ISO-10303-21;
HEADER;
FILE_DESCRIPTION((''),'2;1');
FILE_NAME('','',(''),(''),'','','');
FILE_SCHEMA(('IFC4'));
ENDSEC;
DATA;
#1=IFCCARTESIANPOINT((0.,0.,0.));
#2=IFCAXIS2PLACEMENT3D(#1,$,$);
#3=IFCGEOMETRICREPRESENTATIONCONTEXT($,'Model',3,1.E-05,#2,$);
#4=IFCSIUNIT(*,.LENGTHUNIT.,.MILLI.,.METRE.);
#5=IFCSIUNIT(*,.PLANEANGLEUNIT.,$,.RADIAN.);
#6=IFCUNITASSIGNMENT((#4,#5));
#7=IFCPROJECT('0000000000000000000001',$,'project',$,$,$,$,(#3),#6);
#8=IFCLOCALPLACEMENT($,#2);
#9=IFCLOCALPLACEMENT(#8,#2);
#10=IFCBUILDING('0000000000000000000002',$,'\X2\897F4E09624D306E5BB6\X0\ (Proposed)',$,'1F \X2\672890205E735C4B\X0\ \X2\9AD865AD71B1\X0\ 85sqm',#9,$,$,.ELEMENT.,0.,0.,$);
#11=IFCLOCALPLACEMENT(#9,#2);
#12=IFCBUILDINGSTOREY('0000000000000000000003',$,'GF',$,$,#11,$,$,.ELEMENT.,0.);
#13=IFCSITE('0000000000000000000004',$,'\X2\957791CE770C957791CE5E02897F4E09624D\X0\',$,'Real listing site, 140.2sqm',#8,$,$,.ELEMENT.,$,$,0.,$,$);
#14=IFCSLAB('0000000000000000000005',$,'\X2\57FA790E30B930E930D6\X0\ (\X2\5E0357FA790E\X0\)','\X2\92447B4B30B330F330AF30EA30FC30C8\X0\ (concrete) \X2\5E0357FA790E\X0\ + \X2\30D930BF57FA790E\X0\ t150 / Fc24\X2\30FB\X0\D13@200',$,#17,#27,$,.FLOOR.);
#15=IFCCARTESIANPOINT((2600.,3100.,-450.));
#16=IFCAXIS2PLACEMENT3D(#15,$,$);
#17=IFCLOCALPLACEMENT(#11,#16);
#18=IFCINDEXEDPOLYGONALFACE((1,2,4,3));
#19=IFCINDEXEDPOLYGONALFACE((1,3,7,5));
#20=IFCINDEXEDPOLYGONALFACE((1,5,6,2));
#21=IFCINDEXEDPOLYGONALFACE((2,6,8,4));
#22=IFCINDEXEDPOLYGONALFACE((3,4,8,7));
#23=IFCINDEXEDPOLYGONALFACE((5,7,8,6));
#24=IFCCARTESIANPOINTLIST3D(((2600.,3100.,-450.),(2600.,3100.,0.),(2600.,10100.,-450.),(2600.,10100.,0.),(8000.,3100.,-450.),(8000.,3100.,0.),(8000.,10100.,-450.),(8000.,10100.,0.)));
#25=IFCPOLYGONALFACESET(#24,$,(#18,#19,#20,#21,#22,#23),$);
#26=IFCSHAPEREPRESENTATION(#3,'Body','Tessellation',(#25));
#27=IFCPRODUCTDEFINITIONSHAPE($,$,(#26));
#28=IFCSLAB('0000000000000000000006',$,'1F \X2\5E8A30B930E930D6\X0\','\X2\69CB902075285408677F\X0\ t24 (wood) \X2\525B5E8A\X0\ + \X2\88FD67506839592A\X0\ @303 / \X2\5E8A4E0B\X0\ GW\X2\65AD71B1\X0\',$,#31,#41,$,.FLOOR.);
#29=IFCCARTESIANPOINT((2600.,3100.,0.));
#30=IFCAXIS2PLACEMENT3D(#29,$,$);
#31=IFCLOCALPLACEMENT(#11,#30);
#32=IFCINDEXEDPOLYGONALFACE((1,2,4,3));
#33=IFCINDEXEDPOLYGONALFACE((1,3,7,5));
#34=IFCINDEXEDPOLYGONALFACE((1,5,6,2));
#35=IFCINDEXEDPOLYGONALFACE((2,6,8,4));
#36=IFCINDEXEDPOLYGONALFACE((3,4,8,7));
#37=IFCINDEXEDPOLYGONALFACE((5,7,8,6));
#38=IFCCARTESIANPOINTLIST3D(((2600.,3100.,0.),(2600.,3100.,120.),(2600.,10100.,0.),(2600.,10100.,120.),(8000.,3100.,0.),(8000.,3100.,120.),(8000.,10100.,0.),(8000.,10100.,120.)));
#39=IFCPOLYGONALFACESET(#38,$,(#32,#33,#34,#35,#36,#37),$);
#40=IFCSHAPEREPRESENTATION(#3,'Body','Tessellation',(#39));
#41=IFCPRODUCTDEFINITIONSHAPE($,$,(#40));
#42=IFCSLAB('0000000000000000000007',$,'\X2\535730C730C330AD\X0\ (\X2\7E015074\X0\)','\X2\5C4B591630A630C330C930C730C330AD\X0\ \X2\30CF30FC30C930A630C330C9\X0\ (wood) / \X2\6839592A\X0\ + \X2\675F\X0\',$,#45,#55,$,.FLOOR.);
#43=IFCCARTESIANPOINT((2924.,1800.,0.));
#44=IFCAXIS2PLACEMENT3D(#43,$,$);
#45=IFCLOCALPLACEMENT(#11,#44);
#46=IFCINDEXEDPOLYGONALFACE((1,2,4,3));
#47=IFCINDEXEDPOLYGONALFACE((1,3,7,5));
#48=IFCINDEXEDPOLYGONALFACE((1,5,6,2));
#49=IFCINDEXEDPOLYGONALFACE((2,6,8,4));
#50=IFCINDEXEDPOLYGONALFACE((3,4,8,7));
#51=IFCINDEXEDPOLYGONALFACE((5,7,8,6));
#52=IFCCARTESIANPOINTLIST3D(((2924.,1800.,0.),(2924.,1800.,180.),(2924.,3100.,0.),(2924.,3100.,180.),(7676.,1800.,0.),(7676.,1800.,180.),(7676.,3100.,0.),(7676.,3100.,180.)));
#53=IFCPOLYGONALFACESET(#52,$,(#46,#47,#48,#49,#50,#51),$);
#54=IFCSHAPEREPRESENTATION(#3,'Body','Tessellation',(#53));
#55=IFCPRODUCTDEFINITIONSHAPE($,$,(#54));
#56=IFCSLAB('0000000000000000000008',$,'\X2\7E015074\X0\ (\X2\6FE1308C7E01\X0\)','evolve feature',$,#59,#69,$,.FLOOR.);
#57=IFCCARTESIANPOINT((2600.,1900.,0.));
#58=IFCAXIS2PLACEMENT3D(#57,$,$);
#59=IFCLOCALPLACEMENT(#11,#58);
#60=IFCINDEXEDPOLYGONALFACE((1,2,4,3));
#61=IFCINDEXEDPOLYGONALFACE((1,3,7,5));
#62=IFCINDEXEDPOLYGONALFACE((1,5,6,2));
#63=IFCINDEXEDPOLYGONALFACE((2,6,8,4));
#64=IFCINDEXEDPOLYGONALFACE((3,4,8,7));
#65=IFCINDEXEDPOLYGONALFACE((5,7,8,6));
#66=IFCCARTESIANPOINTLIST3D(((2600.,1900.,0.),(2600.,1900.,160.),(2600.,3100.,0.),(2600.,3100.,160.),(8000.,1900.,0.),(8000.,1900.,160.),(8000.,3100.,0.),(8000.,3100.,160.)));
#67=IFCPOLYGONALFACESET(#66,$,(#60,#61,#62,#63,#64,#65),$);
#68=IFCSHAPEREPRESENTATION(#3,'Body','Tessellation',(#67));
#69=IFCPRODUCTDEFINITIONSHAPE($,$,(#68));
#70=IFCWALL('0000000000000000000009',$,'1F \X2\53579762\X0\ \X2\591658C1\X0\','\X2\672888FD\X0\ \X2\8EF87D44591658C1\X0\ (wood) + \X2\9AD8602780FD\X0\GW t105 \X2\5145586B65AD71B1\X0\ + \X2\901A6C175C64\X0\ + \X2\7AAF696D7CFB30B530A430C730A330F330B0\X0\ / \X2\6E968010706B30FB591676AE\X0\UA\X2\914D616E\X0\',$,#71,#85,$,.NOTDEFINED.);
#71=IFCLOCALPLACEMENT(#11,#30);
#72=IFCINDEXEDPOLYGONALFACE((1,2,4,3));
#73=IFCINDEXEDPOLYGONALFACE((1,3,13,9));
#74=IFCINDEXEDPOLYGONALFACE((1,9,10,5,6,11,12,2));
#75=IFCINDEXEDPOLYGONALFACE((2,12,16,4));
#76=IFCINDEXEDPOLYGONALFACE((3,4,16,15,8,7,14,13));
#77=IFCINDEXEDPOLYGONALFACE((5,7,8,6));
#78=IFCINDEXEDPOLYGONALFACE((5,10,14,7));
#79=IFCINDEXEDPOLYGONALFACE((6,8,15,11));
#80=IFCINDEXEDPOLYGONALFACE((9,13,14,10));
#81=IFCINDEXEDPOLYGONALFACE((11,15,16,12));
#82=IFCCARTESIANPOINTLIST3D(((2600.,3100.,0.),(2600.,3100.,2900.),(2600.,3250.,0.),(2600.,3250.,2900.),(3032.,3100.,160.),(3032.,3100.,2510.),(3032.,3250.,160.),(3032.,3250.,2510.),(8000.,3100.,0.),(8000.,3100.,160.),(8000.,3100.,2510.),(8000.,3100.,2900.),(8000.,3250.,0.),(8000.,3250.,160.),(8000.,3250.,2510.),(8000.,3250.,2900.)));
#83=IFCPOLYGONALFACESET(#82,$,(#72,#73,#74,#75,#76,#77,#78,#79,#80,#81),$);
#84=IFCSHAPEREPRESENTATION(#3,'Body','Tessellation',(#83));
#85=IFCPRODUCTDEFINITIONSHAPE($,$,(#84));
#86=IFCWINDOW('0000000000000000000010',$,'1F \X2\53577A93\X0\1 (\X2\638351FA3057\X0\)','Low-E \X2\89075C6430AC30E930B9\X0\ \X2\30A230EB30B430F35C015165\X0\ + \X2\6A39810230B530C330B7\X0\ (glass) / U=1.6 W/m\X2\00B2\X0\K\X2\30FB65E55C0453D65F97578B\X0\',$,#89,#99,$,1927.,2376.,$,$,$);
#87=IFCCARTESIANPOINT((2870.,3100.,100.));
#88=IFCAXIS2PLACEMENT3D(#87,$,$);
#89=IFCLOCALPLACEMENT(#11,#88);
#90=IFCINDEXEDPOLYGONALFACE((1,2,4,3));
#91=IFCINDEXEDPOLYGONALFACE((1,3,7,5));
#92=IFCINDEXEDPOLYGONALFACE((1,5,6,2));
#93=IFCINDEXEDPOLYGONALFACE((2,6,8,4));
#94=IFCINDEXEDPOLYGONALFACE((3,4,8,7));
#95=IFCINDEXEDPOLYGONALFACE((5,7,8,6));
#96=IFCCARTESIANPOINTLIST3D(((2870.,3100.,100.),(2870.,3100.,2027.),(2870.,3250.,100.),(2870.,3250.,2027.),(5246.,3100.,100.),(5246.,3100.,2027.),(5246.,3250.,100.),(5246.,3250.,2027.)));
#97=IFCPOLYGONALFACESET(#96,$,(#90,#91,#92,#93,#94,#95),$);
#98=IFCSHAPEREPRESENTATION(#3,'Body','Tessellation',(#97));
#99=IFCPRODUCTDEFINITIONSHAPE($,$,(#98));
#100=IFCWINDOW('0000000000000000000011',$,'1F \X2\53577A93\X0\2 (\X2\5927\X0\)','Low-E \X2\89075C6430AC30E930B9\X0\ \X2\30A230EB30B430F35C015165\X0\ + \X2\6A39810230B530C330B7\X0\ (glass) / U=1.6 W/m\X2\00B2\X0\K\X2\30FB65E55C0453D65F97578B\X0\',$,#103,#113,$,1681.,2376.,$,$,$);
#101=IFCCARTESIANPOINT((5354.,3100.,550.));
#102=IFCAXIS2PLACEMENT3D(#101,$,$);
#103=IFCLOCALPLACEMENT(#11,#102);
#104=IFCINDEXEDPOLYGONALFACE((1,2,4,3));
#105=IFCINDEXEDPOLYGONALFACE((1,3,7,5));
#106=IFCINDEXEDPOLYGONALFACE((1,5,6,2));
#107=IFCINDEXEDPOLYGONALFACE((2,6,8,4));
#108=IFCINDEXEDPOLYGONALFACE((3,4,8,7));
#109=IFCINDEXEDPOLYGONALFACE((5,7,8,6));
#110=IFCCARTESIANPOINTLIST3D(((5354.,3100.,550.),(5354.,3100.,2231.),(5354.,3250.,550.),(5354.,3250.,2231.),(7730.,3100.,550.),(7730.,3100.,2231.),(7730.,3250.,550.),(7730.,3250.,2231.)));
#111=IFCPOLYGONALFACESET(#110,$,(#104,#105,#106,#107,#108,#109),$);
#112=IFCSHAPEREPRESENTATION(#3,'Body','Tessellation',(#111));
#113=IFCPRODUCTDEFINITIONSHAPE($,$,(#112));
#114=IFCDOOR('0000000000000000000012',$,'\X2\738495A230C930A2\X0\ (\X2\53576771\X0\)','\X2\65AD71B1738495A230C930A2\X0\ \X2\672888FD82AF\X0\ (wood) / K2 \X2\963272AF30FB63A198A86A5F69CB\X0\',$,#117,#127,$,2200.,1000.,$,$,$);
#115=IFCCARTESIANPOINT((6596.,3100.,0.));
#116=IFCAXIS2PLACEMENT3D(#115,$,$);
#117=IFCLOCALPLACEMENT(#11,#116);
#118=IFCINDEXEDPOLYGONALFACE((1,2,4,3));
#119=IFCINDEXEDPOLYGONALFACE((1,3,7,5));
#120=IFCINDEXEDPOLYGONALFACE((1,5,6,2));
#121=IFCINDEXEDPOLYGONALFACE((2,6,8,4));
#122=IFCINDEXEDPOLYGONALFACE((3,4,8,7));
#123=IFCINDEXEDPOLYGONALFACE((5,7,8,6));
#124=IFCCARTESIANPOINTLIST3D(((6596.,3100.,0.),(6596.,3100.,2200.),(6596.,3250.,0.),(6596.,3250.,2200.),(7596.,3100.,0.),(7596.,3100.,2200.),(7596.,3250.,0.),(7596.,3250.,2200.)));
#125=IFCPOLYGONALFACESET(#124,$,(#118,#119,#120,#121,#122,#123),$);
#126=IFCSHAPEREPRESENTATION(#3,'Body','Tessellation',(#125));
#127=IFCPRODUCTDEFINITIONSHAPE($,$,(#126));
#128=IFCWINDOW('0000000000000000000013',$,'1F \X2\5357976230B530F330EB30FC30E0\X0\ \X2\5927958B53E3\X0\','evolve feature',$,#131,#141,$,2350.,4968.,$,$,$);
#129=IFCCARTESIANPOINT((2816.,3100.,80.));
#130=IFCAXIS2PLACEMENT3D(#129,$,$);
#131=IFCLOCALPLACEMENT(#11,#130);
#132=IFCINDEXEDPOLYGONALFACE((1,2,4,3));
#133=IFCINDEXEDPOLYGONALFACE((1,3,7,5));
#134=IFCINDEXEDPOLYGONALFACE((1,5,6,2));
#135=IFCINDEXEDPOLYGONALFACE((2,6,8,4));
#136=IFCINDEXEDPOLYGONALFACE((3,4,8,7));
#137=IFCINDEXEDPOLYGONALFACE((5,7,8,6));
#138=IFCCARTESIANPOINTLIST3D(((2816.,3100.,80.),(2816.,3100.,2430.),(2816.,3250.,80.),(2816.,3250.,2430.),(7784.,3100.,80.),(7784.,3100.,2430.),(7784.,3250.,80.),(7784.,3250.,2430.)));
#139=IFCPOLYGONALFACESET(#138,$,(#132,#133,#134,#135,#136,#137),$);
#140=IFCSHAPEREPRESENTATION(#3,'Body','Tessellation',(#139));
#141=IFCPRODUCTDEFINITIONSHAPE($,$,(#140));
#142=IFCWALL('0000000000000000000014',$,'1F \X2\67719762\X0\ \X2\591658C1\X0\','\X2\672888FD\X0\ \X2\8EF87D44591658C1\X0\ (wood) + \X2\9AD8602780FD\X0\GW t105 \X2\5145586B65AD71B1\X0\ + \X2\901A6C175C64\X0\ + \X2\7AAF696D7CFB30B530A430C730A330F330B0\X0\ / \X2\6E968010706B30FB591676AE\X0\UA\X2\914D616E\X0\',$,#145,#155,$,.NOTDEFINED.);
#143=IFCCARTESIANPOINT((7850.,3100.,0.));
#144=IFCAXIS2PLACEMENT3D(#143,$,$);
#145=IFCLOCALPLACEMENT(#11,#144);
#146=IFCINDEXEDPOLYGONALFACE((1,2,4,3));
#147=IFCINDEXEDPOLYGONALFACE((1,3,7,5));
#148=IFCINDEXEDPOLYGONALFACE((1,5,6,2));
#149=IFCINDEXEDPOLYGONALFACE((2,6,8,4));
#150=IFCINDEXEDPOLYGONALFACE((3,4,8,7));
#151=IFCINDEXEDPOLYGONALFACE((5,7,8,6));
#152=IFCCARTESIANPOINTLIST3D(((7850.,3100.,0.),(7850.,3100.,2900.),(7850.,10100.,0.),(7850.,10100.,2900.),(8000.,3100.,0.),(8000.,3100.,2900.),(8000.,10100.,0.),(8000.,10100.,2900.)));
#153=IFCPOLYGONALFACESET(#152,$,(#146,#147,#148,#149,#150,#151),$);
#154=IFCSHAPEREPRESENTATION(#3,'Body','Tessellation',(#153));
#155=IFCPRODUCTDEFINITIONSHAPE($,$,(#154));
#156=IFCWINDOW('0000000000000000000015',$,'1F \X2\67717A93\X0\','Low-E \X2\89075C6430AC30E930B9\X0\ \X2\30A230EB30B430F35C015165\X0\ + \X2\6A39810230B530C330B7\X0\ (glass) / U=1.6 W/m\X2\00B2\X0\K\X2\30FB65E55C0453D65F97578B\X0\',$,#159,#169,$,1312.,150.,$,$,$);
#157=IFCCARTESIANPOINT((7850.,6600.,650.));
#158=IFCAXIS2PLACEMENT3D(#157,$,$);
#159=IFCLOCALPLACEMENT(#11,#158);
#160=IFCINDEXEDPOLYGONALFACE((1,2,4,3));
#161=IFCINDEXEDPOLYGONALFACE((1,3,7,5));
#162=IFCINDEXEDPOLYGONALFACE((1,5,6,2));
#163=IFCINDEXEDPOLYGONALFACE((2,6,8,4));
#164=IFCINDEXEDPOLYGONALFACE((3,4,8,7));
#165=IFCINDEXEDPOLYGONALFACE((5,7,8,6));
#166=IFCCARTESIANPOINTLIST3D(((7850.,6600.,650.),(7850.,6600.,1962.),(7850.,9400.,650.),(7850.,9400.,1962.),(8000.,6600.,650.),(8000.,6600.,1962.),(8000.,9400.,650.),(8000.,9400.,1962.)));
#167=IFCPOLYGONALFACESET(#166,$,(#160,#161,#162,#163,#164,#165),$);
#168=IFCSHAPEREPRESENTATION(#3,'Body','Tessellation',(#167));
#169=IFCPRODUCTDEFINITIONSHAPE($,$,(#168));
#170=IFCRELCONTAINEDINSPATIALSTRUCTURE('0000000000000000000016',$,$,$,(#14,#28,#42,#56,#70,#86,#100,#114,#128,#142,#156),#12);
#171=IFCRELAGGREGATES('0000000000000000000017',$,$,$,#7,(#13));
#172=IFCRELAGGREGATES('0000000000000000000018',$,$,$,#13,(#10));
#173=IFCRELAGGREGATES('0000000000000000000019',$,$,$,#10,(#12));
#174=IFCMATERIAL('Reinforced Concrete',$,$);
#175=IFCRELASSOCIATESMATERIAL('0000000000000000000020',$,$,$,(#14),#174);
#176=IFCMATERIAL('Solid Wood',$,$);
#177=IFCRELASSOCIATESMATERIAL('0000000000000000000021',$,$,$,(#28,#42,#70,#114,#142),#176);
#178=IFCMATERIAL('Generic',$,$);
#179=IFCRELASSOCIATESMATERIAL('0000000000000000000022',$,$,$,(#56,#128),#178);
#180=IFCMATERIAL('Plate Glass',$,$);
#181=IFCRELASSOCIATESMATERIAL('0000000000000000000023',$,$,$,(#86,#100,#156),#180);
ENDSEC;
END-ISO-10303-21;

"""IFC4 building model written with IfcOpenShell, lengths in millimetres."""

from ifc_helpers import new_model, si_unit, frame, frame_2d, origin, place, context, project, spatial, rectangle, extrude, material, element, fill, save


model = new_model("IFC4")

# Units and contexts
model_context = context("Model", 3, precision=1e-05, world=origin())
ifc_project = project(units=[si_unit("LENGTHUNIT", "METRE", prefix="MILLI"), si_unit("PLANEANGLEUNIT", "RADIAN")], contexts=[model_context])

# Site, building, storey
site_placement = place(None, origin())
site = spatial("IfcSite", under=ifc_project, at=site_placement, Name="長野県長野市西三才", ObjectType="Real listing site, 140.2sqm", CompositionType="ELEMENT", RefElevation=0.0)
building_placement = place(site_placement, origin())
building = spatial("IfcBuilding", under=site, at=building_placement, Name="西三才の家 (Proposed)", ObjectType="1F 木造平屋 高断熱 85sqm", CompositionType="ELEMENT", ElevationOfRefHeight=0.0, ElevationOfTerrain=0.0)
storey_placement = place(building_placement, origin())
storey = spatial("IfcBuildingStorey", under=building, at=storey_placement, Name="GF", CompositionType="ELEMENT", Elevation=0.0)

# Slabs
ifc_material_1 = material(Name="Reinforced Concrete")
slab_1_placement = place(storey_placement, frame((2600.0, 3100.0, -450.0)))
element("IfcSlab", 1, at=slab_1_placement, inside=storey, material=ifc_material_1, Name="基礎スラブ (布基礎)", Description="鉄筋コンクリート (concrete) 布基礎 + ベタ基礎 t150 / Fc24・D13@200", PredefinedType="FLOOR", context=model_context, shape_type="SweptSolid", body=[
    extrude(rectangle(XDim=5400.0, YDim=7000.0, at=frame_2d((2700.0, 3500.0))), frame((2600.0, 3100.0, -450.0)), (0.0, 0.0, 1.0), 450.0),
])
ifc_material_2 = material(Name="Solid Wood")
slab_2_placement = place(storey_placement, frame((2600.0, 3100.0, 0.0)))
element("IfcSlab", 2, at=slab_2_placement, inside=storey, material=ifc_material_2, Name="1F 床スラブ", Description="構造用合板 t24 (wood) 剛床 + 製材根太 @303 / 床下 GW断熱", PredefinedType="FLOOR", context=model_context, shape_type="SweptSolid", body=[
    extrude(rectangle(XDim=5400.0, YDim=7000.0, at=frame_2d((2700.0, 3500.0))), frame((2600.0, 3100.0, 0.0)), (0.0, 0.0, 1.0), 120.0),
])
slab_3_placement = place(storey_placement, frame((2924.0, 1800.0, 0.0)))
element("IfcSlab", 3, at=slab_3_placement, inside=storey, material=ifc_material_2, Name="南デッキ (縁側)", Description="屋外ウッドデッキ ハードウッド (wood) / 根太 + 束", PredefinedType="FLOOR", context=model_context, shape_type="SweptSolid", body=[
    extrude(rectangle(XDim=4752.0, YDim=1300.0, at=frame_2d((2376.0, 650.0))), frame((2924.0, 1800.0, 0.0)), (0.0, 0.0, 1.0), 180.0),
])
ifc_material_3 = material(Name="Generic")
slab_4_placement = place(storey_placement, frame((2600.0, 1900.0, 0.0)))
element("IfcSlab", 4, at=slab_4_placement, inside=storey, material=ifc_material_3, Name="縁側 (濡れ縁)", Description="evolve feature", PredefinedType="FLOOR", context=model_context, shape_type="SweptSolid", body=[
    extrude(rectangle(XDim=5400.0, YDim=1200.0, at=frame_2d((2700.0, 600.0))), frame((2600.0, 1900.0, 0.0)), (0.0, 0.0, 1.0), 160.0),
])

# Wall, openings, windows, door
wall_1_placement = place(storey_placement, frame((2600.0, 3100.0, 0.0)))
wall_1 = element("IfcWall", 5, at=wall_1_placement, inside=storey, material=ifc_material_2, Name="1F 南面 外壁", Description="木製 軸組外壁 (wood) + 高性能GW t105 充填断熱 + 通気層 + 窯業系サイディング / 準耐火・外皮UA配慮", PredefinedType="NOTDEFINED", context=model_context, shape_type="SweptSolid", body=[
    extrude(rectangle(XDim=5400.0, YDim=150.0, at=frame_2d((2700.0, 75.0))), frame((2600.0, 3100.0, 0.0)), (0.0, 0.0, 1.0), 2900.0),
])
opening_1_placement = place(storey_placement, frame((2870.0, 3100.0, 100.0)))
opening_1 = element("IfcOpeningElement", 6, at=opening_1_placement, cuts=wall_1, PredefinedType="NOTDEFINED", context=model_context, shape_type="SweptSolid", body=[
    extrude(rectangle(XDim=2376.0, YDim=150.0, at=frame_2d((1188.0, 75.0))), frame((2870.0, 3100.0, 100.0)), (0.0, 0.0, 1.0), 1927.0),
])
opening_2_placement = place(storey_placement, frame((5354.0, 3100.0, 550.0)))
opening_2 = element("IfcOpeningElement", 7, at=opening_2_placement, cuts=wall_1, PredefinedType="NOTDEFINED", context=model_context, shape_type="SweptSolid", body=[
    extrude(rectangle(XDim=2376.0, YDim=150.0, at=frame_2d((1188.0, 75.0))), frame((5354.0, 3100.0, 550.0)), (0.0, 0.0, 1.0), 1681.0),
])
opening_3_placement = place(storey_placement, frame((6596.0, 3100.0, 0.0)))
opening_3 = element("IfcOpeningElement", 8, at=opening_3_placement, cuts=wall_1, PredefinedType="NOTDEFINED", context=model_context, shape_type="SweptSolid", body=[
    extrude(rectangle(XDim=1000.0, YDim=150.0, at=frame_2d((500.0, 75.0))), frame((6596.0, 3100.0, 0.0)), (0.0, 0.0, 1.0), 2200.0),
])
opening_4_placement = place(storey_placement, frame((2816.0, 3100.0, 80.0)))
opening_4 = element("IfcOpeningElement", 9, at=opening_4_placement, cuts=wall_1, PredefinedType="NOTDEFINED", context=model_context, shape_type="SweptSolid", body=[
    extrude(rectangle(XDim=4968.0, YDim=150.0, at=frame_2d((2484.0, 75.0))), frame((2816.0, 3100.0, 80.0)), (0.0, 0.0, 1.0), 2350.0),
])
ifc_material_4 = material(Name="Plate Glass")
window_1_placement = place(storey_placement, frame((2870.0, 3100.0, 100.0)))
window_1 = element("IfcWindow", 10, at=window_1_placement, inside=storey, material=ifc_material_4, Name="1F 南窓1 (掃出し)", Description="Low-E 複層ガラス アルゴン封入 + 樹脂サッシ (glass) / U=1.6 W/m²K・日射取得型", OverallHeight=1927.0, OverallWidth=2376.0, context=model_context, shape_type="SweptSolid", body=[
    extrude(rectangle(XDim=2376.0, YDim=150.0, at=frame_2d((1188.0, 75.0))), frame((2870.0, 3100.0, 100.0)), (0.0, 0.0, 1.0), 1927.0),
])
fill(opening_1, window_1)
window_2_placement = place(storey_placement, frame((5354.0, 3100.0, 550.0)))
window_2 = element("IfcWindow", 11, at=window_2_placement, inside=storey, material=ifc_material_4, Name="1F 南窓2 (大)", Description="Low-E 複層ガラス アルゴン封入 + 樹脂サッシ (glass) / U=1.6 W/m²K・日射取得型", OverallHeight=1681.0, OverallWidth=2376.0, context=model_context, shape_type="SweptSolid", body=[
    extrude(rectangle(XDim=2376.0, YDim=150.0, at=frame_2d((1188.0, 75.0))), frame((5354.0, 3100.0, 550.0)), (0.0, 0.0, 1.0), 1681.0),
])
fill(opening_2, window_2)
door_placement = place(storey_placement, frame((6596.0, 3100.0, 0.0)))
door = element("IfcDoor", 12, at=door_placement, inside=storey, material=ifc_material_2, Name="玄関ドア (南東)", Description="断熱玄関ドア 木製芯 (wood) / K2 防犯・採風機構", OverallHeight=2200.0, OverallWidth=1000.0, context=model_context, shape_type="SweptSolid", body=[
    extrude(rectangle(XDim=1000.0, YDim=150.0, at=frame_2d((500.0, 75.0))), frame((6596.0, 3100.0, 0.0)), (0.0, 0.0, 1.0), 2200.0),
])
fill(opening_3, door)
window_3_placement = place(storey_placement, frame((2816.0, 3100.0, 80.0)))
window_3 = element("IfcWindow", 13, at=window_3_placement, inside=storey, material=ifc_material_3, Name="1F 南面サンルーム 大開口", Description="evolve feature", OverallHeight=2350.0, OverallWidth=4968.0, context=model_context, shape_type="SweptSolid", body=[
    extrude(rectangle(XDim=4968.0, YDim=150.0, at=frame_2d((2484.0, 75.0))), frame((2816.0, 3100.0, 80.0)), (0.0, 0.0, 1.0), 2350.0),
])
fill(opening_4, window_3)

# Wall, opening, window
wall_2_placement = place(storey_placement, frame((7850.0, 3100.0, 0.0)))
wall_2 = element("IfcWall", 14, at=wall_2_placement, inside=storey, material=ifc_material_2, Name="1F 東面 外壁", Description="木製 軸組外壁 (wood) + 高性能GW t105 充填断熱 + 通気層 + 窯業系サイディング / 準耐火・外皮UA配慮", PredefinedType="NOTDEFINED", context=model_context, shape_type="SweptSolid", body=[
    extrude(rectangle(XDim=150.0, YDim=7000.0, at=frame_2d((75.0, 3500.0))), frame((7850.0, 3100.0, 0.0)), (0.0, 0.0, 1.0), 2900.0),
])
opening_5_placement = place(storey_placement, frame((7850.0, 6600.0, 650.0)))
opening_5 = element("IfcOpeningElement", 15, at=opening_5_placement, cuts=wall_2, PredefinedType="NOTDEFINED", context=model_context, shape_type="SweptSolid", body=[
    extrude(rectangle(XDim=150.0, YDim=2800.0, at=frame_2d((75.0, 1400.0))), frame((7850.0, 6600.0, 650.0)), (0.0, 0.0, 1.0), 1312.0),
])
window_4_placement = place(storey_placement, frame((7850.0, 6600.0, 650.0)))
window_4 = element("IfcWindow", 16, at=window_4_placement, inside=storey, material=ifc_material_4, Name="1F 東窓", Description="Low-E 複層ガラス アルゴン封入 + 樹脂サッシ (glass) / U=1.6 W/m²K・日射取得型", OverallHeight=1312.0, OverallWidth=150.0, context=model_context, shape_type="SweptSolid", body=[
    extrude(rectangle(XDim=150.0, YDim=2800.0, at=frame_2d((75.0, 1400.0))), frame((7850.0, 6600.0, 650.0)), (0.0, 0.0, 1.0), 1312.0),
])
fill(opening_5, window_4)

save(model, "model.ifc")
